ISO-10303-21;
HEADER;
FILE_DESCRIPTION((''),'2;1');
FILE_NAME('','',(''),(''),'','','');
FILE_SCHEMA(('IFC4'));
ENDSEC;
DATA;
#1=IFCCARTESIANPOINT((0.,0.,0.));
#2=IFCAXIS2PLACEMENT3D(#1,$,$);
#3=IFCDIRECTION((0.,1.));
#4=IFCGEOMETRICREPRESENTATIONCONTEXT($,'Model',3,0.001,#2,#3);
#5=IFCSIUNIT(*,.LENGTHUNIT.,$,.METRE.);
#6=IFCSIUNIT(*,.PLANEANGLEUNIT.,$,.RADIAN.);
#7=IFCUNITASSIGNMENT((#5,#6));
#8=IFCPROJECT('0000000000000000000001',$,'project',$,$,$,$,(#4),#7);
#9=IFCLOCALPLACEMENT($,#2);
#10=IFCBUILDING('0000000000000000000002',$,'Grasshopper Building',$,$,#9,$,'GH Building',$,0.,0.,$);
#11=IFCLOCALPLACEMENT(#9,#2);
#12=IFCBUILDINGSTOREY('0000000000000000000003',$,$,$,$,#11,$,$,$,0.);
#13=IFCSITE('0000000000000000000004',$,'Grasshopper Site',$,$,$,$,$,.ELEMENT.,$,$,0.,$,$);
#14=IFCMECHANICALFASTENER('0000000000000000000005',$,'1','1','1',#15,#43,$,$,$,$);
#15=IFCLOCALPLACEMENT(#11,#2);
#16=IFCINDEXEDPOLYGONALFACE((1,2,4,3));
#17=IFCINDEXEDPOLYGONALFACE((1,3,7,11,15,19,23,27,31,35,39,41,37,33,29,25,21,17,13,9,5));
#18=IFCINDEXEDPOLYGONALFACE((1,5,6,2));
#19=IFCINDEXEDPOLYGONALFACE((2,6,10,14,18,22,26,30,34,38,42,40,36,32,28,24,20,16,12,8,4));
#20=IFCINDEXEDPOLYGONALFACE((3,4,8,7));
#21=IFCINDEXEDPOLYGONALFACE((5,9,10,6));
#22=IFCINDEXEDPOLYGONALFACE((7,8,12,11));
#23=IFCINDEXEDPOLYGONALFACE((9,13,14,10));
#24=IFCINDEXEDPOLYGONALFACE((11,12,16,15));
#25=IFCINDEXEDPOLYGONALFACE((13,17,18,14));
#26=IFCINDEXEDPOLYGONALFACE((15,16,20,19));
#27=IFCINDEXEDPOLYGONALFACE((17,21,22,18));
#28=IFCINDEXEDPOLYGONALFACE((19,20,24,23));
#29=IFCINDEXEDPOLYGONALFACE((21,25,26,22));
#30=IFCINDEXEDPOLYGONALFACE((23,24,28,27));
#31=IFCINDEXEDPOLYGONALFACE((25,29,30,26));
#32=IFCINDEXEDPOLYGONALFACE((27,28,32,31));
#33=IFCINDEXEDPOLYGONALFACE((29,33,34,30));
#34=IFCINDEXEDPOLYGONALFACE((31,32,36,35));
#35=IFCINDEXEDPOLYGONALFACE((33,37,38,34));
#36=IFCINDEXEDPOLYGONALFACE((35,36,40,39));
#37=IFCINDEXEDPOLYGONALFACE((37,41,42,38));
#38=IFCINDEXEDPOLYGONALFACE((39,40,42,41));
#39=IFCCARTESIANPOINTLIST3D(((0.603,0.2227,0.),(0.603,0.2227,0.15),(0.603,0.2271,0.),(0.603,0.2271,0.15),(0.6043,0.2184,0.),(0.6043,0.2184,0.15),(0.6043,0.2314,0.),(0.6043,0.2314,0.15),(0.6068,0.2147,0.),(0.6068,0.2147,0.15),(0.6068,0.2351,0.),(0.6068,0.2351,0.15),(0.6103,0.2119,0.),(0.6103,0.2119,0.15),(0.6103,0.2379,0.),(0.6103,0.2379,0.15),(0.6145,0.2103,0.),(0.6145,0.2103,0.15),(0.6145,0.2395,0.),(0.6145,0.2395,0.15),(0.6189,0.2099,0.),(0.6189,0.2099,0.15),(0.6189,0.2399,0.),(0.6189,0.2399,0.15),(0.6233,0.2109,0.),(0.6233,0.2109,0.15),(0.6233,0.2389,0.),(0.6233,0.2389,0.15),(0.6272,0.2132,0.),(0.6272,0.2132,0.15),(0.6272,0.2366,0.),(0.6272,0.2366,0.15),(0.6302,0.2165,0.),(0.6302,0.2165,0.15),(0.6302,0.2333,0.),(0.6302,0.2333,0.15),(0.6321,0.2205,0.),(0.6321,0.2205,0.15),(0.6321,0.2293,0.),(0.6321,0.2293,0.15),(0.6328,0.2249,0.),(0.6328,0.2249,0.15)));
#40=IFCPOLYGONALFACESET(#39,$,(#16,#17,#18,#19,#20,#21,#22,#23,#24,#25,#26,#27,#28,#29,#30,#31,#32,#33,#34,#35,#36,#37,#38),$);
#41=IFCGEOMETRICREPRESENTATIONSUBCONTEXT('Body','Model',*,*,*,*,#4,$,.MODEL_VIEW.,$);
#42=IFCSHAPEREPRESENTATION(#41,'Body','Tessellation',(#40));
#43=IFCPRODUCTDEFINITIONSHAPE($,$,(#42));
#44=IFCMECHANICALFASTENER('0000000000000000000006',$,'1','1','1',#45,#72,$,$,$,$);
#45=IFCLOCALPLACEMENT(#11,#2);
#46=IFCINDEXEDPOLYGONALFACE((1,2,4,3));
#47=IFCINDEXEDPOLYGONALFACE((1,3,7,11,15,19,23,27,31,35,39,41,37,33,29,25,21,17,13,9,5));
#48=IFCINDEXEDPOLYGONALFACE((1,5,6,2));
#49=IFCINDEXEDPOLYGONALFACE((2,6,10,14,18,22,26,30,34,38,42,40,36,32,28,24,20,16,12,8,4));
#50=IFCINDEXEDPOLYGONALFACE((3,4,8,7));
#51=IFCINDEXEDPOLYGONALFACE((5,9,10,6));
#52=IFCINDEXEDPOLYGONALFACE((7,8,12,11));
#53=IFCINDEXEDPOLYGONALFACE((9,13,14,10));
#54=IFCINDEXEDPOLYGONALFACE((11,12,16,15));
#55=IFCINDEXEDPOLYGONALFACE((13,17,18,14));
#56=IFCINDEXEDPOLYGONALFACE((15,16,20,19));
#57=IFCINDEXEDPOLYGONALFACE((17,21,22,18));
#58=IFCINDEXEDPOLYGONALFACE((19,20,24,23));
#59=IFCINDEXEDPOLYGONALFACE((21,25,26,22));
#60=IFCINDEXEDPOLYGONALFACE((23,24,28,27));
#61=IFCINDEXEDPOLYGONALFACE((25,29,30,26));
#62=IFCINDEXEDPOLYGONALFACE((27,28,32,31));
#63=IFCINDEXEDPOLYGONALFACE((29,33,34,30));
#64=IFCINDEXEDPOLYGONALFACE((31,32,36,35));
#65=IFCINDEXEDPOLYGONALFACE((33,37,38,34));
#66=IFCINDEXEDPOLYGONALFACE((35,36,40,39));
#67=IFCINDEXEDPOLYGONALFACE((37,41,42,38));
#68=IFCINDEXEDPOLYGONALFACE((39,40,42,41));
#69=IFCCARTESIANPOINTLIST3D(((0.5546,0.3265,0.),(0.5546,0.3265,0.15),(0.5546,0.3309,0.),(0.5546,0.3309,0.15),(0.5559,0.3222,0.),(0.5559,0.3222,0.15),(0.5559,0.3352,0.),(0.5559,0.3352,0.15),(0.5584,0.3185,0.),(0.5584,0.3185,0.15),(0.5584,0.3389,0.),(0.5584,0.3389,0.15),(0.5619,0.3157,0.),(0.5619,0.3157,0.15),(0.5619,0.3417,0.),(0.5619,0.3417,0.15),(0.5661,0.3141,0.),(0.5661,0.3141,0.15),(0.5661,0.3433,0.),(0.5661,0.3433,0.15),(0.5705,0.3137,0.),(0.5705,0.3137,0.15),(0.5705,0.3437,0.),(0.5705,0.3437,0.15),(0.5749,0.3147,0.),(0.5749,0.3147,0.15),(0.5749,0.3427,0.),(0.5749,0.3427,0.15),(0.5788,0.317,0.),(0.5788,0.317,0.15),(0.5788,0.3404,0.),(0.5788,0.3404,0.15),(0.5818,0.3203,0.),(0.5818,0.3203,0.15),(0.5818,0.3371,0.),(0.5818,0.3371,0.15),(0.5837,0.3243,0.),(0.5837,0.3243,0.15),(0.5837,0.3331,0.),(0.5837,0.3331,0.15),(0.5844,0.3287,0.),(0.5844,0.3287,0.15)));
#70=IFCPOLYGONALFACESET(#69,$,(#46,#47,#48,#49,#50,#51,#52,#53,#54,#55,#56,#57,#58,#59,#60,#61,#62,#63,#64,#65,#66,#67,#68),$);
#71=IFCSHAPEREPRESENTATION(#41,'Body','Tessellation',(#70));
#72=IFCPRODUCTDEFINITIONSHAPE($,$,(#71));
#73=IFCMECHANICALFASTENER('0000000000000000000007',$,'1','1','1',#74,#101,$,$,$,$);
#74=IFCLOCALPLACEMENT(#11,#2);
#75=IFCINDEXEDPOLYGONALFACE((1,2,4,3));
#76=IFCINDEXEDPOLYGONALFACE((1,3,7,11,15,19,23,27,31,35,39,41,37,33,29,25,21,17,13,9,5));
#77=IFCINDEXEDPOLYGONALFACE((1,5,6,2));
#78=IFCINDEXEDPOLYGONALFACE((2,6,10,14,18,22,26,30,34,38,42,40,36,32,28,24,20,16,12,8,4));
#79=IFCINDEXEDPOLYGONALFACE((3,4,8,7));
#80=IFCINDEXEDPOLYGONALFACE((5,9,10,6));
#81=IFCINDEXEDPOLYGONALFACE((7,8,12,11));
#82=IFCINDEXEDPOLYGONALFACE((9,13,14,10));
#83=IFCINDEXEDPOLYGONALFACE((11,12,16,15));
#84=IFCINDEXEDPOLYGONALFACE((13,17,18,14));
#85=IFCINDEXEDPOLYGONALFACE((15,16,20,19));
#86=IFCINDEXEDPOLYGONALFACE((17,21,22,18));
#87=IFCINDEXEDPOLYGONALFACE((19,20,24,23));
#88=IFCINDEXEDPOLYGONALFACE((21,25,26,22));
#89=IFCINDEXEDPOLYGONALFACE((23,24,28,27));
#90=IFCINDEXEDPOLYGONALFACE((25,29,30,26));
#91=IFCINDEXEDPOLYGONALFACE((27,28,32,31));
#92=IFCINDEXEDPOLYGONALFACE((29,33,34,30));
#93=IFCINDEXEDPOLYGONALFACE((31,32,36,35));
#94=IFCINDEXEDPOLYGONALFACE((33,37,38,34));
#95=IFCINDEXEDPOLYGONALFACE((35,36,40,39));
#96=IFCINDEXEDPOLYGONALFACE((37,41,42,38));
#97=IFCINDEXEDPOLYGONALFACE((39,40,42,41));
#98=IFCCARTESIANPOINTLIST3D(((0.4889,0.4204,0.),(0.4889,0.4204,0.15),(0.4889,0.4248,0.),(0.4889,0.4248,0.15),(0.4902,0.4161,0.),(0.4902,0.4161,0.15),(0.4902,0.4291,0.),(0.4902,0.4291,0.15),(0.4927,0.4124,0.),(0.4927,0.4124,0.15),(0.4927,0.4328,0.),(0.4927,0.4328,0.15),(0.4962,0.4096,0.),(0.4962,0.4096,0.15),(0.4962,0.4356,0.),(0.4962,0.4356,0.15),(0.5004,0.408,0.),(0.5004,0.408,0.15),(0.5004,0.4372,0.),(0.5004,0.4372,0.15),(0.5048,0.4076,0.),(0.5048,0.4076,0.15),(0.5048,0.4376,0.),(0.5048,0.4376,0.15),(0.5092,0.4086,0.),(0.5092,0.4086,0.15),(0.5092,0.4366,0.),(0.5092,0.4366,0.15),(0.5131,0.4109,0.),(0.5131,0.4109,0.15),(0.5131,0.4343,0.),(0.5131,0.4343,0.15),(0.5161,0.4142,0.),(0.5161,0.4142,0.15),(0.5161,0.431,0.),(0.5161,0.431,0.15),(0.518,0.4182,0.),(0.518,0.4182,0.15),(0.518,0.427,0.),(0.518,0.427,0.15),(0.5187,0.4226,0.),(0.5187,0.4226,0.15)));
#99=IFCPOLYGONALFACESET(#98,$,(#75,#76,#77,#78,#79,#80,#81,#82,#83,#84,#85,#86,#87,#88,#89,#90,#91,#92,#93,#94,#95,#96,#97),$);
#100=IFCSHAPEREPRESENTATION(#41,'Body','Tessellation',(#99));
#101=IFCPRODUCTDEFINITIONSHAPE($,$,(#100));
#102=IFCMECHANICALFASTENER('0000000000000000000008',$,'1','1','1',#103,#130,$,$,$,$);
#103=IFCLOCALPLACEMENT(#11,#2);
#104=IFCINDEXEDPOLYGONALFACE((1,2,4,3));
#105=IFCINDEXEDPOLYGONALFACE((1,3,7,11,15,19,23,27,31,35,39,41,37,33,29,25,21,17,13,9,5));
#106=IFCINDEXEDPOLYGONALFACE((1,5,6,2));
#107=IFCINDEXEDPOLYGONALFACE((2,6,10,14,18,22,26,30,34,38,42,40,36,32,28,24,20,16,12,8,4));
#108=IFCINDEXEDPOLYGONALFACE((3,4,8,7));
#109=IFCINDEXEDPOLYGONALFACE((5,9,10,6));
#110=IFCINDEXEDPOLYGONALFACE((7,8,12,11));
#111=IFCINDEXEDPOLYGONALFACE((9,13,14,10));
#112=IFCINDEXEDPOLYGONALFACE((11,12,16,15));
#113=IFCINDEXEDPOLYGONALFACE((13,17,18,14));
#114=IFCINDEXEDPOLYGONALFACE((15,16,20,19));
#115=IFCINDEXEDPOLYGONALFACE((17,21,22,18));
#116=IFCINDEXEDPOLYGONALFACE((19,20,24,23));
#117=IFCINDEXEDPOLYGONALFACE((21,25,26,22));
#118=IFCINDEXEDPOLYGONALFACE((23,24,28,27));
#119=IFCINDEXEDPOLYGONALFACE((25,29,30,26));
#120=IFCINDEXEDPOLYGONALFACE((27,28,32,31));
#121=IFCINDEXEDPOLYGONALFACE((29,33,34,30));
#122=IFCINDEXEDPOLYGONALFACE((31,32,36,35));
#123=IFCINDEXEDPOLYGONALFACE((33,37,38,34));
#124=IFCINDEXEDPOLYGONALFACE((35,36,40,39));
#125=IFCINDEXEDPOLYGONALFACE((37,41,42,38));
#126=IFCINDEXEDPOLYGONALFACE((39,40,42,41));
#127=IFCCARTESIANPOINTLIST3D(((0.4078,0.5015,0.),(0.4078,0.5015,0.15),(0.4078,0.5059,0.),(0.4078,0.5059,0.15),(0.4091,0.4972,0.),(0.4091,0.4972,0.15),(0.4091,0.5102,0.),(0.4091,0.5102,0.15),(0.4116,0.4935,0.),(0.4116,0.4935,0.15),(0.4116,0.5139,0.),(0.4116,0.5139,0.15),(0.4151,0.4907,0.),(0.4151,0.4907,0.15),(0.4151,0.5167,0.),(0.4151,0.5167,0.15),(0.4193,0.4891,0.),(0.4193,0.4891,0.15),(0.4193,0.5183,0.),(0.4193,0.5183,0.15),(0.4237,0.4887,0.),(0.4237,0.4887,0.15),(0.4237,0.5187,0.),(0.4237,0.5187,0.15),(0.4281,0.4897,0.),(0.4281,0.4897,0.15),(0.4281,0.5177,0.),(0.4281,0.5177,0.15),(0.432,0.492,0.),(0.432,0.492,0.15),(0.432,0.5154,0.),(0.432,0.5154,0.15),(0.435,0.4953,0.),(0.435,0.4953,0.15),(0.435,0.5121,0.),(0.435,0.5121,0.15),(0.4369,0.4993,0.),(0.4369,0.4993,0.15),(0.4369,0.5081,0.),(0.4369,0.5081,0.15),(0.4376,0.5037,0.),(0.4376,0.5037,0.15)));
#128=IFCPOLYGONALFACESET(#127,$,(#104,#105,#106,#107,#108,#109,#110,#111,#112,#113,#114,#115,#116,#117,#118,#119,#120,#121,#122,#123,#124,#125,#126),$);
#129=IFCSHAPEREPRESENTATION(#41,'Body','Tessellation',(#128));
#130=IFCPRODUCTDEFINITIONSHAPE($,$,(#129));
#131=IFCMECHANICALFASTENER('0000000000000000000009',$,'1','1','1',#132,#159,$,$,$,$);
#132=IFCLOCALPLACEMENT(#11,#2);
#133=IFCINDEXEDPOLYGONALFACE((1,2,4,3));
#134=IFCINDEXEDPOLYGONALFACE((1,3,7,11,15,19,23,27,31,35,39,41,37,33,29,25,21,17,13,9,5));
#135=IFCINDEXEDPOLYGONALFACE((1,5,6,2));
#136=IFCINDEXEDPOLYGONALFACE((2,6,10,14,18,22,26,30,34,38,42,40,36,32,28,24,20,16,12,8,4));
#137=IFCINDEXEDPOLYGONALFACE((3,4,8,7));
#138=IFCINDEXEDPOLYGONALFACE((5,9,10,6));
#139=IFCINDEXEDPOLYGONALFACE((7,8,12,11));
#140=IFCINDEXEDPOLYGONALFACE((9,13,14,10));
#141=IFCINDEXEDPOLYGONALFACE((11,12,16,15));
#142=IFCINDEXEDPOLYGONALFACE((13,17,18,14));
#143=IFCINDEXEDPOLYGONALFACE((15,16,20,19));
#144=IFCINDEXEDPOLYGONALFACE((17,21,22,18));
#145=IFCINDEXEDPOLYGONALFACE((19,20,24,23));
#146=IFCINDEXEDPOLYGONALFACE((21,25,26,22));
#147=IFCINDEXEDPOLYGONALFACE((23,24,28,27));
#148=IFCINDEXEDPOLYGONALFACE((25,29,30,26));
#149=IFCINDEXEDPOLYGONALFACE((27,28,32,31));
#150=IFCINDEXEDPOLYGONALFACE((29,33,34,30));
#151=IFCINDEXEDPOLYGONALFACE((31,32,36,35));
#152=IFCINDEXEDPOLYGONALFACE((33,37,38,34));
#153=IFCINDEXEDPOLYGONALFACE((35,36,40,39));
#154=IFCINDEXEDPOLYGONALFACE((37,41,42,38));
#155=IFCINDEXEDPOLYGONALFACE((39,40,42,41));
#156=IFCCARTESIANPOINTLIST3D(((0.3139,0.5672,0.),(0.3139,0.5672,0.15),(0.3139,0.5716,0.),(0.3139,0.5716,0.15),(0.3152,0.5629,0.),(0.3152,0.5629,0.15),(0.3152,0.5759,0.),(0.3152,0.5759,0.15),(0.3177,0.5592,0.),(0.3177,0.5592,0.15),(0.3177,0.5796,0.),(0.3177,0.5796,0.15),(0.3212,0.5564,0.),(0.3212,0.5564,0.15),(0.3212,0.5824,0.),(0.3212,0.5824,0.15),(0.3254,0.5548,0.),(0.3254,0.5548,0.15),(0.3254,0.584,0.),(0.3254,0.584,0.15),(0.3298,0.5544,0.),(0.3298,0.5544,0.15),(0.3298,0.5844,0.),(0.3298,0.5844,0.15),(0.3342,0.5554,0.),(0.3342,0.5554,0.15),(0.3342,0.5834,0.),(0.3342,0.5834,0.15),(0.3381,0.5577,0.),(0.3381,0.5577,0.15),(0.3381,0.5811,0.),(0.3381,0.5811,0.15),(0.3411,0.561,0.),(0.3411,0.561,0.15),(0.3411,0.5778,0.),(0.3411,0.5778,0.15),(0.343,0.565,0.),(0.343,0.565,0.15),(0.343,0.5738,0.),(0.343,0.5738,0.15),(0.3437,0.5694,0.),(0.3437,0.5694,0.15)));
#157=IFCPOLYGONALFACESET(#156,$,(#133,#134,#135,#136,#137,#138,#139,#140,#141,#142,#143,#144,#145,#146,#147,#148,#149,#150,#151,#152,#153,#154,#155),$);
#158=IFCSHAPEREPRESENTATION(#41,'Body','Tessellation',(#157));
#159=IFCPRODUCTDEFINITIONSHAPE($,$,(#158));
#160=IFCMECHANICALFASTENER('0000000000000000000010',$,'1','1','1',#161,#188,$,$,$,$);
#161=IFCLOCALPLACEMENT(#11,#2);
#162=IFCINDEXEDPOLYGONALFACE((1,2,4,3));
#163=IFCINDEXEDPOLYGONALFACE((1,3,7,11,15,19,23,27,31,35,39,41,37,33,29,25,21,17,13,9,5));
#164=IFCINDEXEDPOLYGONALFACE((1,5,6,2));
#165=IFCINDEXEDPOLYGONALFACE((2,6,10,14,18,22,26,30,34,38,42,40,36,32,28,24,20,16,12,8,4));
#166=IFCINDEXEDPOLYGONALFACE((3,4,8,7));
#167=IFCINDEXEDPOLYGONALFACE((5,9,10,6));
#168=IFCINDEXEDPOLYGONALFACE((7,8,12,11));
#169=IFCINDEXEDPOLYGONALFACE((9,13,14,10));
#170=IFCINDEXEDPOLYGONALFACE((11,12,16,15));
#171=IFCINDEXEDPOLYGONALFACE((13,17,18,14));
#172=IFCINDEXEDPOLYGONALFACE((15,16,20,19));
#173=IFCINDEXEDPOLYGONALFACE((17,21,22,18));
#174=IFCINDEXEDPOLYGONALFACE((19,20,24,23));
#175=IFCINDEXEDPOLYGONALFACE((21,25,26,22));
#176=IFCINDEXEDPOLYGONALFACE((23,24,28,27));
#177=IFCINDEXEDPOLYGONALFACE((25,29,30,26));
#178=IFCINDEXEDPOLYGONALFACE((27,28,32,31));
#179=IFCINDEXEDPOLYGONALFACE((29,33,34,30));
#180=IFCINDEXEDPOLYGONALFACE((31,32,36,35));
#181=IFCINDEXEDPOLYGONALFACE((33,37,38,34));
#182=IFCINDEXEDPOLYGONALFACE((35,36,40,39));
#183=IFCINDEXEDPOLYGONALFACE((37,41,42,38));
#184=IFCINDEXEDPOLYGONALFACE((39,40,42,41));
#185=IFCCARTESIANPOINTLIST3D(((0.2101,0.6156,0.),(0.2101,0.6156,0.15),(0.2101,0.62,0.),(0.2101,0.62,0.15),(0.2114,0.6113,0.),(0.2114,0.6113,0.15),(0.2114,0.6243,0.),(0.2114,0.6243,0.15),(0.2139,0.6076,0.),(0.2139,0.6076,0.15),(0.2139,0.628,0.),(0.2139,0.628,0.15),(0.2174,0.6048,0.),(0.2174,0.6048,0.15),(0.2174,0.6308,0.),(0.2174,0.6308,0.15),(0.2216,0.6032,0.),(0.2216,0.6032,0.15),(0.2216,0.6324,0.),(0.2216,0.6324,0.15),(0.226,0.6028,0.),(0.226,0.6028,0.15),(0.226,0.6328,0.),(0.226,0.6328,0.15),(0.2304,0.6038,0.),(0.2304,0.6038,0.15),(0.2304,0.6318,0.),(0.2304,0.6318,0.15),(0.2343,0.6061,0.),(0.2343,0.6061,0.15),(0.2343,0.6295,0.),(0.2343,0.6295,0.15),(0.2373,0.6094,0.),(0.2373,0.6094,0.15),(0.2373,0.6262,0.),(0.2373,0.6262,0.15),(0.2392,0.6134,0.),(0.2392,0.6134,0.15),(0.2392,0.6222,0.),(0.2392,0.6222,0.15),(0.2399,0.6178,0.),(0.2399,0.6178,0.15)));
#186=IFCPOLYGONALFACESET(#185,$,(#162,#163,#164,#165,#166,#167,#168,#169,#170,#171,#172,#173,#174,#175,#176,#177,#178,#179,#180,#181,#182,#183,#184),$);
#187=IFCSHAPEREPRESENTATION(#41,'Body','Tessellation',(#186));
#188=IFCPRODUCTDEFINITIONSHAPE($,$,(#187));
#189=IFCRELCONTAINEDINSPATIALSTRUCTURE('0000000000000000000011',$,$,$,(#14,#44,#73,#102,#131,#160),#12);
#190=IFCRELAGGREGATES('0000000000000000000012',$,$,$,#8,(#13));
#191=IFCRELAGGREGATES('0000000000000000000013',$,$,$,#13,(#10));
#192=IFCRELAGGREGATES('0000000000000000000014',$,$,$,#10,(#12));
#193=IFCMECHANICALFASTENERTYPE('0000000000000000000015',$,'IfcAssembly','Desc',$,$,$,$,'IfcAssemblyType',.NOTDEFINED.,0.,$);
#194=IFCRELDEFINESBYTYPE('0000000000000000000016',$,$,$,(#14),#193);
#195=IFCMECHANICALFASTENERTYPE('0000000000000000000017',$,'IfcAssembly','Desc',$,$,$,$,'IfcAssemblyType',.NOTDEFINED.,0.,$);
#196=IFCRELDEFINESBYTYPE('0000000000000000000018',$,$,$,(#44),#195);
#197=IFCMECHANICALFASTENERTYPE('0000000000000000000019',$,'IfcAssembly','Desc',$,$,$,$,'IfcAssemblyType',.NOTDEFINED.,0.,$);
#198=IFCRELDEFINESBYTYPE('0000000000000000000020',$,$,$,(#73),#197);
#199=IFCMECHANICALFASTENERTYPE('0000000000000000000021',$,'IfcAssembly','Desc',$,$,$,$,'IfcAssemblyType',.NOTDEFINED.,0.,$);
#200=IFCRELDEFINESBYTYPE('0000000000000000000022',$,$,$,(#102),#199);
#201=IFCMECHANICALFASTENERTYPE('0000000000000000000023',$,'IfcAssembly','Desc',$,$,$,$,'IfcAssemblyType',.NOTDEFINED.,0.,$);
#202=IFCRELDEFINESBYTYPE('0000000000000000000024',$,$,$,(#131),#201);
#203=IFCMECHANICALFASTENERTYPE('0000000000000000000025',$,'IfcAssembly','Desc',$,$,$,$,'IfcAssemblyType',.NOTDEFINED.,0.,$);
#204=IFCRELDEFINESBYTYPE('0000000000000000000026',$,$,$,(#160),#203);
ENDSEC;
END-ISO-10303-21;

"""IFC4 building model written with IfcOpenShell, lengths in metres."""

from ifc_helpers import new_model, si_unit, direction, frame, origin, place, context, subcontext, project, spatial, circle, extrude, source, transform, mapped, type_object, type_shapes, element, save


model = new_model("IFC4")

# Units and contexts
model_context = context("Model", 3, precision=0.001, world=origin(), true_north=direction((0.0, 1.0)))
body_context = subcontext(model_context, "Body", "Model", "MODEL_VIEW")
ifc_project = project(units=[si_unit("LENGTHUNIT", "METRE"), si_unit("PLANEANGLEUNIT", "RADIAN")], contexts=[model_context])

# Site, building, storey
site = spatial("IfcSite", under=ifc_project, Name="Grasshopper Site", CompositionType="ELEMENT", RefElevation=0.0)
building_placement = place(None, origin())
building = spatial("IfcBuilding", under=site, at=building_placement, Name="Grasshopper Building", LongName="GH Building", ElevationOfRefHeight=0.0, ElevationOfTerrain=0.0)
storey_placement = place(building_placement, origin())
storey = spatial("IfcBuildingStorey", under=building, at=storey_placement, Elevation=0.0)

# Mechanical fasteners
mechanical_fastener_type_1 = type_object("IfcMechanicalFastenerType", Name="IfcAssembly", Description="Desc", ElementType="IfcAssemblyType", NominalDiameter=0.0)
shared_shape_1 = source(origin(), body_context, "Body", "SweptSolid", [
    extrude(circle(Radius=0.015), frame((0.6178, 0.2249, 0.0)), (0.0, 0.0, 1.0), 0.15),
])
type_shapes(mechanical_fastener_type_1, [shared_shape_1])
mechanical_fastener_1_placement = place(storey_placement, origin())
element("IfcMechanicalFastener", 1, at=mechanical_fastener_1_placement, inside=storey, type_object=mechanical_fastener_type_1, Name="1", Description="1", ObjectType="1", context=body_context, shape_type="MappedRepresentation", body=[
    mapped(shared_shape_1, transform((0.0, 0.0, 0.0), scale=1.0)),
])
mechanical_fastener_type_2 = type_object("IfcMechanicalFastenerType", Name="IfcAssembly", Description="Desc", ElementType="IfcAssemblyType", NominalDiameter=0.0)
shared_shape_2 = source(origin(), body_context, "Body", "SweptSolid", [
    extrude(circle(Radius=0.015), frame((0.5694, 0.3287, 0.0)), (0.0, 0.0, 1.0), 0.15),
])
type_shapes(mechanical_fastener_type_2, [shared_shape_2])
mechanical_fastener_2_placement = place(storey_placement, origin())
element("IfcMechanicalFastener", 2, at=mechanical_fastener_2_placement, inside=storey, type_object=mechanical_fastener_type_2, Name="1", Description="1", ObjectType="1", context=body_context, shape_type="MappedRepresentation", body=[
    mapped(shared_shape_2, transform((0.0, 0.0, 0.0), scale=1.0)),
])
mechanical_fastener_type_3 = type_object("IfcMechanicalFastenerType", Name="IfcAssembly", Description="Desc", ElementType="IfcAssemblyType", NominalDiameter=0.0)
shared_shape_3 = source(origin(), body_context, "Body", "SweptSolid", [
    extrude(circle(Radius=0.015), frame((0.5037, 0.4226, 0.0)), (0.0, 0.0, 1.0), 0.15),
])
type_shapes(mechanical_fastener_type_3, [shared_shape_3])
mechanical_fastener_3_placement = place(storey_placement, origin())
element("IfcMechanicalFastener", 3, at=mechanical_fastener_3_placement, inside=storey, type_object=mechanical_fastener_type_3, Name="1", Description="1", ObjectType="1", context=body_context, shape_type="MappedRepresentation", body=[
    mapped(shared_shape_3, transform((0.0, 0.0, 0.0), scale=1.0)),
])
mechanical_fastener_type_4 = type_object("IfcMechanicalFastenerType", Name="IfcAssembly", Description="Desc", ElementType="IfcAssemblyType", NominalDiameter=0.0)
shared_shape_4 = source(origin(), body_context, "Body", "SweptSolid", [
    extrude(circle(Radius=0.015), frame((0.4226, 0.5037, 0.0)), (0.0, 0.0, 1.0), 0.15),
])
type_shapes(mechanical_fastener_type_4, [shared_shape_4])
mechanical_fastener_4_placement = place(storey_placement, origin())
element("IfcMechanicalFastener", 4, at=mechanical_fastener_4_placement, inside=storey, type_object=mechanical_fastener_type_4, Name="1", Description="1", ObjectType="1", context=body_context, shape_type="MappedRepresentation", body=[
    mapped(shared_shape_4, transform((0.0, 0.0, 0.0), scale=1.0)),
])
mechanical_fastener_type_5 = type_object("IfcMechanicalFastenerType", Name="IfcAssembly", Description="Desc", ElementType="IfcAssemblyType", NominalDiameter=0.0)
shared_shape_5 = source(origin(), body_context, "Body", "SweptSolid", [
    extrude(circle(Radius=0.015), frame((0.3287, 0.5694, 0.0)), (0.0, 0.0, 1.0), 0.15),
])
type_shapes(mechanical_fastener_type_5, [shared_shape_5])
mechanical_fastener_5_placement = place(storey_placement, origin())
element("IfcMechanicalFastener", 5, at=mechanical_fastener_5_placement, inside=storey, type_object=mechanical_fastener_type_5, Name="1", Description="1", ObjectType="1", context=body_context, shape_type="MappedRepresentation", body=[
    mapped(shared_shape_5, transform((0.0, 0.0, 0.0), scale=1.0)),
])
mechanical_fastener_type_6 = type_object("IfcMechanicalFastenerType", Name="IfcAssembly", Description="Desc", ElementType="IfcAssemblyType", NominalDiameter=0.0)
shared_shape_6 = source(origin(), body_context, "Body", "SweptSolid", [
    extrude(circle(Radius=0.015), frame((0.2249, 0.6178, 0.0)), (0.0, 0.0, 1.0), 0.15),
])
type_shapes(mechanical_fastener_type_6, [shared_shape_6])
mechanical_fastener_6_placement = place(storey_placement, origin())
element("IfcMechanicalFastener", 6, at=mechanical_fastener_6_placement, inside=storey, type_object=mechanical_fastener_type_6, Name="1", Description="1", ObjectType="1", context=body_context, shape_type="MappedRepresentation", body=[
    mapped(shared_shape_6, transform((0.0, 0.0, 0.0), scale=1.0)),
])

save(model, "model.ifc")
